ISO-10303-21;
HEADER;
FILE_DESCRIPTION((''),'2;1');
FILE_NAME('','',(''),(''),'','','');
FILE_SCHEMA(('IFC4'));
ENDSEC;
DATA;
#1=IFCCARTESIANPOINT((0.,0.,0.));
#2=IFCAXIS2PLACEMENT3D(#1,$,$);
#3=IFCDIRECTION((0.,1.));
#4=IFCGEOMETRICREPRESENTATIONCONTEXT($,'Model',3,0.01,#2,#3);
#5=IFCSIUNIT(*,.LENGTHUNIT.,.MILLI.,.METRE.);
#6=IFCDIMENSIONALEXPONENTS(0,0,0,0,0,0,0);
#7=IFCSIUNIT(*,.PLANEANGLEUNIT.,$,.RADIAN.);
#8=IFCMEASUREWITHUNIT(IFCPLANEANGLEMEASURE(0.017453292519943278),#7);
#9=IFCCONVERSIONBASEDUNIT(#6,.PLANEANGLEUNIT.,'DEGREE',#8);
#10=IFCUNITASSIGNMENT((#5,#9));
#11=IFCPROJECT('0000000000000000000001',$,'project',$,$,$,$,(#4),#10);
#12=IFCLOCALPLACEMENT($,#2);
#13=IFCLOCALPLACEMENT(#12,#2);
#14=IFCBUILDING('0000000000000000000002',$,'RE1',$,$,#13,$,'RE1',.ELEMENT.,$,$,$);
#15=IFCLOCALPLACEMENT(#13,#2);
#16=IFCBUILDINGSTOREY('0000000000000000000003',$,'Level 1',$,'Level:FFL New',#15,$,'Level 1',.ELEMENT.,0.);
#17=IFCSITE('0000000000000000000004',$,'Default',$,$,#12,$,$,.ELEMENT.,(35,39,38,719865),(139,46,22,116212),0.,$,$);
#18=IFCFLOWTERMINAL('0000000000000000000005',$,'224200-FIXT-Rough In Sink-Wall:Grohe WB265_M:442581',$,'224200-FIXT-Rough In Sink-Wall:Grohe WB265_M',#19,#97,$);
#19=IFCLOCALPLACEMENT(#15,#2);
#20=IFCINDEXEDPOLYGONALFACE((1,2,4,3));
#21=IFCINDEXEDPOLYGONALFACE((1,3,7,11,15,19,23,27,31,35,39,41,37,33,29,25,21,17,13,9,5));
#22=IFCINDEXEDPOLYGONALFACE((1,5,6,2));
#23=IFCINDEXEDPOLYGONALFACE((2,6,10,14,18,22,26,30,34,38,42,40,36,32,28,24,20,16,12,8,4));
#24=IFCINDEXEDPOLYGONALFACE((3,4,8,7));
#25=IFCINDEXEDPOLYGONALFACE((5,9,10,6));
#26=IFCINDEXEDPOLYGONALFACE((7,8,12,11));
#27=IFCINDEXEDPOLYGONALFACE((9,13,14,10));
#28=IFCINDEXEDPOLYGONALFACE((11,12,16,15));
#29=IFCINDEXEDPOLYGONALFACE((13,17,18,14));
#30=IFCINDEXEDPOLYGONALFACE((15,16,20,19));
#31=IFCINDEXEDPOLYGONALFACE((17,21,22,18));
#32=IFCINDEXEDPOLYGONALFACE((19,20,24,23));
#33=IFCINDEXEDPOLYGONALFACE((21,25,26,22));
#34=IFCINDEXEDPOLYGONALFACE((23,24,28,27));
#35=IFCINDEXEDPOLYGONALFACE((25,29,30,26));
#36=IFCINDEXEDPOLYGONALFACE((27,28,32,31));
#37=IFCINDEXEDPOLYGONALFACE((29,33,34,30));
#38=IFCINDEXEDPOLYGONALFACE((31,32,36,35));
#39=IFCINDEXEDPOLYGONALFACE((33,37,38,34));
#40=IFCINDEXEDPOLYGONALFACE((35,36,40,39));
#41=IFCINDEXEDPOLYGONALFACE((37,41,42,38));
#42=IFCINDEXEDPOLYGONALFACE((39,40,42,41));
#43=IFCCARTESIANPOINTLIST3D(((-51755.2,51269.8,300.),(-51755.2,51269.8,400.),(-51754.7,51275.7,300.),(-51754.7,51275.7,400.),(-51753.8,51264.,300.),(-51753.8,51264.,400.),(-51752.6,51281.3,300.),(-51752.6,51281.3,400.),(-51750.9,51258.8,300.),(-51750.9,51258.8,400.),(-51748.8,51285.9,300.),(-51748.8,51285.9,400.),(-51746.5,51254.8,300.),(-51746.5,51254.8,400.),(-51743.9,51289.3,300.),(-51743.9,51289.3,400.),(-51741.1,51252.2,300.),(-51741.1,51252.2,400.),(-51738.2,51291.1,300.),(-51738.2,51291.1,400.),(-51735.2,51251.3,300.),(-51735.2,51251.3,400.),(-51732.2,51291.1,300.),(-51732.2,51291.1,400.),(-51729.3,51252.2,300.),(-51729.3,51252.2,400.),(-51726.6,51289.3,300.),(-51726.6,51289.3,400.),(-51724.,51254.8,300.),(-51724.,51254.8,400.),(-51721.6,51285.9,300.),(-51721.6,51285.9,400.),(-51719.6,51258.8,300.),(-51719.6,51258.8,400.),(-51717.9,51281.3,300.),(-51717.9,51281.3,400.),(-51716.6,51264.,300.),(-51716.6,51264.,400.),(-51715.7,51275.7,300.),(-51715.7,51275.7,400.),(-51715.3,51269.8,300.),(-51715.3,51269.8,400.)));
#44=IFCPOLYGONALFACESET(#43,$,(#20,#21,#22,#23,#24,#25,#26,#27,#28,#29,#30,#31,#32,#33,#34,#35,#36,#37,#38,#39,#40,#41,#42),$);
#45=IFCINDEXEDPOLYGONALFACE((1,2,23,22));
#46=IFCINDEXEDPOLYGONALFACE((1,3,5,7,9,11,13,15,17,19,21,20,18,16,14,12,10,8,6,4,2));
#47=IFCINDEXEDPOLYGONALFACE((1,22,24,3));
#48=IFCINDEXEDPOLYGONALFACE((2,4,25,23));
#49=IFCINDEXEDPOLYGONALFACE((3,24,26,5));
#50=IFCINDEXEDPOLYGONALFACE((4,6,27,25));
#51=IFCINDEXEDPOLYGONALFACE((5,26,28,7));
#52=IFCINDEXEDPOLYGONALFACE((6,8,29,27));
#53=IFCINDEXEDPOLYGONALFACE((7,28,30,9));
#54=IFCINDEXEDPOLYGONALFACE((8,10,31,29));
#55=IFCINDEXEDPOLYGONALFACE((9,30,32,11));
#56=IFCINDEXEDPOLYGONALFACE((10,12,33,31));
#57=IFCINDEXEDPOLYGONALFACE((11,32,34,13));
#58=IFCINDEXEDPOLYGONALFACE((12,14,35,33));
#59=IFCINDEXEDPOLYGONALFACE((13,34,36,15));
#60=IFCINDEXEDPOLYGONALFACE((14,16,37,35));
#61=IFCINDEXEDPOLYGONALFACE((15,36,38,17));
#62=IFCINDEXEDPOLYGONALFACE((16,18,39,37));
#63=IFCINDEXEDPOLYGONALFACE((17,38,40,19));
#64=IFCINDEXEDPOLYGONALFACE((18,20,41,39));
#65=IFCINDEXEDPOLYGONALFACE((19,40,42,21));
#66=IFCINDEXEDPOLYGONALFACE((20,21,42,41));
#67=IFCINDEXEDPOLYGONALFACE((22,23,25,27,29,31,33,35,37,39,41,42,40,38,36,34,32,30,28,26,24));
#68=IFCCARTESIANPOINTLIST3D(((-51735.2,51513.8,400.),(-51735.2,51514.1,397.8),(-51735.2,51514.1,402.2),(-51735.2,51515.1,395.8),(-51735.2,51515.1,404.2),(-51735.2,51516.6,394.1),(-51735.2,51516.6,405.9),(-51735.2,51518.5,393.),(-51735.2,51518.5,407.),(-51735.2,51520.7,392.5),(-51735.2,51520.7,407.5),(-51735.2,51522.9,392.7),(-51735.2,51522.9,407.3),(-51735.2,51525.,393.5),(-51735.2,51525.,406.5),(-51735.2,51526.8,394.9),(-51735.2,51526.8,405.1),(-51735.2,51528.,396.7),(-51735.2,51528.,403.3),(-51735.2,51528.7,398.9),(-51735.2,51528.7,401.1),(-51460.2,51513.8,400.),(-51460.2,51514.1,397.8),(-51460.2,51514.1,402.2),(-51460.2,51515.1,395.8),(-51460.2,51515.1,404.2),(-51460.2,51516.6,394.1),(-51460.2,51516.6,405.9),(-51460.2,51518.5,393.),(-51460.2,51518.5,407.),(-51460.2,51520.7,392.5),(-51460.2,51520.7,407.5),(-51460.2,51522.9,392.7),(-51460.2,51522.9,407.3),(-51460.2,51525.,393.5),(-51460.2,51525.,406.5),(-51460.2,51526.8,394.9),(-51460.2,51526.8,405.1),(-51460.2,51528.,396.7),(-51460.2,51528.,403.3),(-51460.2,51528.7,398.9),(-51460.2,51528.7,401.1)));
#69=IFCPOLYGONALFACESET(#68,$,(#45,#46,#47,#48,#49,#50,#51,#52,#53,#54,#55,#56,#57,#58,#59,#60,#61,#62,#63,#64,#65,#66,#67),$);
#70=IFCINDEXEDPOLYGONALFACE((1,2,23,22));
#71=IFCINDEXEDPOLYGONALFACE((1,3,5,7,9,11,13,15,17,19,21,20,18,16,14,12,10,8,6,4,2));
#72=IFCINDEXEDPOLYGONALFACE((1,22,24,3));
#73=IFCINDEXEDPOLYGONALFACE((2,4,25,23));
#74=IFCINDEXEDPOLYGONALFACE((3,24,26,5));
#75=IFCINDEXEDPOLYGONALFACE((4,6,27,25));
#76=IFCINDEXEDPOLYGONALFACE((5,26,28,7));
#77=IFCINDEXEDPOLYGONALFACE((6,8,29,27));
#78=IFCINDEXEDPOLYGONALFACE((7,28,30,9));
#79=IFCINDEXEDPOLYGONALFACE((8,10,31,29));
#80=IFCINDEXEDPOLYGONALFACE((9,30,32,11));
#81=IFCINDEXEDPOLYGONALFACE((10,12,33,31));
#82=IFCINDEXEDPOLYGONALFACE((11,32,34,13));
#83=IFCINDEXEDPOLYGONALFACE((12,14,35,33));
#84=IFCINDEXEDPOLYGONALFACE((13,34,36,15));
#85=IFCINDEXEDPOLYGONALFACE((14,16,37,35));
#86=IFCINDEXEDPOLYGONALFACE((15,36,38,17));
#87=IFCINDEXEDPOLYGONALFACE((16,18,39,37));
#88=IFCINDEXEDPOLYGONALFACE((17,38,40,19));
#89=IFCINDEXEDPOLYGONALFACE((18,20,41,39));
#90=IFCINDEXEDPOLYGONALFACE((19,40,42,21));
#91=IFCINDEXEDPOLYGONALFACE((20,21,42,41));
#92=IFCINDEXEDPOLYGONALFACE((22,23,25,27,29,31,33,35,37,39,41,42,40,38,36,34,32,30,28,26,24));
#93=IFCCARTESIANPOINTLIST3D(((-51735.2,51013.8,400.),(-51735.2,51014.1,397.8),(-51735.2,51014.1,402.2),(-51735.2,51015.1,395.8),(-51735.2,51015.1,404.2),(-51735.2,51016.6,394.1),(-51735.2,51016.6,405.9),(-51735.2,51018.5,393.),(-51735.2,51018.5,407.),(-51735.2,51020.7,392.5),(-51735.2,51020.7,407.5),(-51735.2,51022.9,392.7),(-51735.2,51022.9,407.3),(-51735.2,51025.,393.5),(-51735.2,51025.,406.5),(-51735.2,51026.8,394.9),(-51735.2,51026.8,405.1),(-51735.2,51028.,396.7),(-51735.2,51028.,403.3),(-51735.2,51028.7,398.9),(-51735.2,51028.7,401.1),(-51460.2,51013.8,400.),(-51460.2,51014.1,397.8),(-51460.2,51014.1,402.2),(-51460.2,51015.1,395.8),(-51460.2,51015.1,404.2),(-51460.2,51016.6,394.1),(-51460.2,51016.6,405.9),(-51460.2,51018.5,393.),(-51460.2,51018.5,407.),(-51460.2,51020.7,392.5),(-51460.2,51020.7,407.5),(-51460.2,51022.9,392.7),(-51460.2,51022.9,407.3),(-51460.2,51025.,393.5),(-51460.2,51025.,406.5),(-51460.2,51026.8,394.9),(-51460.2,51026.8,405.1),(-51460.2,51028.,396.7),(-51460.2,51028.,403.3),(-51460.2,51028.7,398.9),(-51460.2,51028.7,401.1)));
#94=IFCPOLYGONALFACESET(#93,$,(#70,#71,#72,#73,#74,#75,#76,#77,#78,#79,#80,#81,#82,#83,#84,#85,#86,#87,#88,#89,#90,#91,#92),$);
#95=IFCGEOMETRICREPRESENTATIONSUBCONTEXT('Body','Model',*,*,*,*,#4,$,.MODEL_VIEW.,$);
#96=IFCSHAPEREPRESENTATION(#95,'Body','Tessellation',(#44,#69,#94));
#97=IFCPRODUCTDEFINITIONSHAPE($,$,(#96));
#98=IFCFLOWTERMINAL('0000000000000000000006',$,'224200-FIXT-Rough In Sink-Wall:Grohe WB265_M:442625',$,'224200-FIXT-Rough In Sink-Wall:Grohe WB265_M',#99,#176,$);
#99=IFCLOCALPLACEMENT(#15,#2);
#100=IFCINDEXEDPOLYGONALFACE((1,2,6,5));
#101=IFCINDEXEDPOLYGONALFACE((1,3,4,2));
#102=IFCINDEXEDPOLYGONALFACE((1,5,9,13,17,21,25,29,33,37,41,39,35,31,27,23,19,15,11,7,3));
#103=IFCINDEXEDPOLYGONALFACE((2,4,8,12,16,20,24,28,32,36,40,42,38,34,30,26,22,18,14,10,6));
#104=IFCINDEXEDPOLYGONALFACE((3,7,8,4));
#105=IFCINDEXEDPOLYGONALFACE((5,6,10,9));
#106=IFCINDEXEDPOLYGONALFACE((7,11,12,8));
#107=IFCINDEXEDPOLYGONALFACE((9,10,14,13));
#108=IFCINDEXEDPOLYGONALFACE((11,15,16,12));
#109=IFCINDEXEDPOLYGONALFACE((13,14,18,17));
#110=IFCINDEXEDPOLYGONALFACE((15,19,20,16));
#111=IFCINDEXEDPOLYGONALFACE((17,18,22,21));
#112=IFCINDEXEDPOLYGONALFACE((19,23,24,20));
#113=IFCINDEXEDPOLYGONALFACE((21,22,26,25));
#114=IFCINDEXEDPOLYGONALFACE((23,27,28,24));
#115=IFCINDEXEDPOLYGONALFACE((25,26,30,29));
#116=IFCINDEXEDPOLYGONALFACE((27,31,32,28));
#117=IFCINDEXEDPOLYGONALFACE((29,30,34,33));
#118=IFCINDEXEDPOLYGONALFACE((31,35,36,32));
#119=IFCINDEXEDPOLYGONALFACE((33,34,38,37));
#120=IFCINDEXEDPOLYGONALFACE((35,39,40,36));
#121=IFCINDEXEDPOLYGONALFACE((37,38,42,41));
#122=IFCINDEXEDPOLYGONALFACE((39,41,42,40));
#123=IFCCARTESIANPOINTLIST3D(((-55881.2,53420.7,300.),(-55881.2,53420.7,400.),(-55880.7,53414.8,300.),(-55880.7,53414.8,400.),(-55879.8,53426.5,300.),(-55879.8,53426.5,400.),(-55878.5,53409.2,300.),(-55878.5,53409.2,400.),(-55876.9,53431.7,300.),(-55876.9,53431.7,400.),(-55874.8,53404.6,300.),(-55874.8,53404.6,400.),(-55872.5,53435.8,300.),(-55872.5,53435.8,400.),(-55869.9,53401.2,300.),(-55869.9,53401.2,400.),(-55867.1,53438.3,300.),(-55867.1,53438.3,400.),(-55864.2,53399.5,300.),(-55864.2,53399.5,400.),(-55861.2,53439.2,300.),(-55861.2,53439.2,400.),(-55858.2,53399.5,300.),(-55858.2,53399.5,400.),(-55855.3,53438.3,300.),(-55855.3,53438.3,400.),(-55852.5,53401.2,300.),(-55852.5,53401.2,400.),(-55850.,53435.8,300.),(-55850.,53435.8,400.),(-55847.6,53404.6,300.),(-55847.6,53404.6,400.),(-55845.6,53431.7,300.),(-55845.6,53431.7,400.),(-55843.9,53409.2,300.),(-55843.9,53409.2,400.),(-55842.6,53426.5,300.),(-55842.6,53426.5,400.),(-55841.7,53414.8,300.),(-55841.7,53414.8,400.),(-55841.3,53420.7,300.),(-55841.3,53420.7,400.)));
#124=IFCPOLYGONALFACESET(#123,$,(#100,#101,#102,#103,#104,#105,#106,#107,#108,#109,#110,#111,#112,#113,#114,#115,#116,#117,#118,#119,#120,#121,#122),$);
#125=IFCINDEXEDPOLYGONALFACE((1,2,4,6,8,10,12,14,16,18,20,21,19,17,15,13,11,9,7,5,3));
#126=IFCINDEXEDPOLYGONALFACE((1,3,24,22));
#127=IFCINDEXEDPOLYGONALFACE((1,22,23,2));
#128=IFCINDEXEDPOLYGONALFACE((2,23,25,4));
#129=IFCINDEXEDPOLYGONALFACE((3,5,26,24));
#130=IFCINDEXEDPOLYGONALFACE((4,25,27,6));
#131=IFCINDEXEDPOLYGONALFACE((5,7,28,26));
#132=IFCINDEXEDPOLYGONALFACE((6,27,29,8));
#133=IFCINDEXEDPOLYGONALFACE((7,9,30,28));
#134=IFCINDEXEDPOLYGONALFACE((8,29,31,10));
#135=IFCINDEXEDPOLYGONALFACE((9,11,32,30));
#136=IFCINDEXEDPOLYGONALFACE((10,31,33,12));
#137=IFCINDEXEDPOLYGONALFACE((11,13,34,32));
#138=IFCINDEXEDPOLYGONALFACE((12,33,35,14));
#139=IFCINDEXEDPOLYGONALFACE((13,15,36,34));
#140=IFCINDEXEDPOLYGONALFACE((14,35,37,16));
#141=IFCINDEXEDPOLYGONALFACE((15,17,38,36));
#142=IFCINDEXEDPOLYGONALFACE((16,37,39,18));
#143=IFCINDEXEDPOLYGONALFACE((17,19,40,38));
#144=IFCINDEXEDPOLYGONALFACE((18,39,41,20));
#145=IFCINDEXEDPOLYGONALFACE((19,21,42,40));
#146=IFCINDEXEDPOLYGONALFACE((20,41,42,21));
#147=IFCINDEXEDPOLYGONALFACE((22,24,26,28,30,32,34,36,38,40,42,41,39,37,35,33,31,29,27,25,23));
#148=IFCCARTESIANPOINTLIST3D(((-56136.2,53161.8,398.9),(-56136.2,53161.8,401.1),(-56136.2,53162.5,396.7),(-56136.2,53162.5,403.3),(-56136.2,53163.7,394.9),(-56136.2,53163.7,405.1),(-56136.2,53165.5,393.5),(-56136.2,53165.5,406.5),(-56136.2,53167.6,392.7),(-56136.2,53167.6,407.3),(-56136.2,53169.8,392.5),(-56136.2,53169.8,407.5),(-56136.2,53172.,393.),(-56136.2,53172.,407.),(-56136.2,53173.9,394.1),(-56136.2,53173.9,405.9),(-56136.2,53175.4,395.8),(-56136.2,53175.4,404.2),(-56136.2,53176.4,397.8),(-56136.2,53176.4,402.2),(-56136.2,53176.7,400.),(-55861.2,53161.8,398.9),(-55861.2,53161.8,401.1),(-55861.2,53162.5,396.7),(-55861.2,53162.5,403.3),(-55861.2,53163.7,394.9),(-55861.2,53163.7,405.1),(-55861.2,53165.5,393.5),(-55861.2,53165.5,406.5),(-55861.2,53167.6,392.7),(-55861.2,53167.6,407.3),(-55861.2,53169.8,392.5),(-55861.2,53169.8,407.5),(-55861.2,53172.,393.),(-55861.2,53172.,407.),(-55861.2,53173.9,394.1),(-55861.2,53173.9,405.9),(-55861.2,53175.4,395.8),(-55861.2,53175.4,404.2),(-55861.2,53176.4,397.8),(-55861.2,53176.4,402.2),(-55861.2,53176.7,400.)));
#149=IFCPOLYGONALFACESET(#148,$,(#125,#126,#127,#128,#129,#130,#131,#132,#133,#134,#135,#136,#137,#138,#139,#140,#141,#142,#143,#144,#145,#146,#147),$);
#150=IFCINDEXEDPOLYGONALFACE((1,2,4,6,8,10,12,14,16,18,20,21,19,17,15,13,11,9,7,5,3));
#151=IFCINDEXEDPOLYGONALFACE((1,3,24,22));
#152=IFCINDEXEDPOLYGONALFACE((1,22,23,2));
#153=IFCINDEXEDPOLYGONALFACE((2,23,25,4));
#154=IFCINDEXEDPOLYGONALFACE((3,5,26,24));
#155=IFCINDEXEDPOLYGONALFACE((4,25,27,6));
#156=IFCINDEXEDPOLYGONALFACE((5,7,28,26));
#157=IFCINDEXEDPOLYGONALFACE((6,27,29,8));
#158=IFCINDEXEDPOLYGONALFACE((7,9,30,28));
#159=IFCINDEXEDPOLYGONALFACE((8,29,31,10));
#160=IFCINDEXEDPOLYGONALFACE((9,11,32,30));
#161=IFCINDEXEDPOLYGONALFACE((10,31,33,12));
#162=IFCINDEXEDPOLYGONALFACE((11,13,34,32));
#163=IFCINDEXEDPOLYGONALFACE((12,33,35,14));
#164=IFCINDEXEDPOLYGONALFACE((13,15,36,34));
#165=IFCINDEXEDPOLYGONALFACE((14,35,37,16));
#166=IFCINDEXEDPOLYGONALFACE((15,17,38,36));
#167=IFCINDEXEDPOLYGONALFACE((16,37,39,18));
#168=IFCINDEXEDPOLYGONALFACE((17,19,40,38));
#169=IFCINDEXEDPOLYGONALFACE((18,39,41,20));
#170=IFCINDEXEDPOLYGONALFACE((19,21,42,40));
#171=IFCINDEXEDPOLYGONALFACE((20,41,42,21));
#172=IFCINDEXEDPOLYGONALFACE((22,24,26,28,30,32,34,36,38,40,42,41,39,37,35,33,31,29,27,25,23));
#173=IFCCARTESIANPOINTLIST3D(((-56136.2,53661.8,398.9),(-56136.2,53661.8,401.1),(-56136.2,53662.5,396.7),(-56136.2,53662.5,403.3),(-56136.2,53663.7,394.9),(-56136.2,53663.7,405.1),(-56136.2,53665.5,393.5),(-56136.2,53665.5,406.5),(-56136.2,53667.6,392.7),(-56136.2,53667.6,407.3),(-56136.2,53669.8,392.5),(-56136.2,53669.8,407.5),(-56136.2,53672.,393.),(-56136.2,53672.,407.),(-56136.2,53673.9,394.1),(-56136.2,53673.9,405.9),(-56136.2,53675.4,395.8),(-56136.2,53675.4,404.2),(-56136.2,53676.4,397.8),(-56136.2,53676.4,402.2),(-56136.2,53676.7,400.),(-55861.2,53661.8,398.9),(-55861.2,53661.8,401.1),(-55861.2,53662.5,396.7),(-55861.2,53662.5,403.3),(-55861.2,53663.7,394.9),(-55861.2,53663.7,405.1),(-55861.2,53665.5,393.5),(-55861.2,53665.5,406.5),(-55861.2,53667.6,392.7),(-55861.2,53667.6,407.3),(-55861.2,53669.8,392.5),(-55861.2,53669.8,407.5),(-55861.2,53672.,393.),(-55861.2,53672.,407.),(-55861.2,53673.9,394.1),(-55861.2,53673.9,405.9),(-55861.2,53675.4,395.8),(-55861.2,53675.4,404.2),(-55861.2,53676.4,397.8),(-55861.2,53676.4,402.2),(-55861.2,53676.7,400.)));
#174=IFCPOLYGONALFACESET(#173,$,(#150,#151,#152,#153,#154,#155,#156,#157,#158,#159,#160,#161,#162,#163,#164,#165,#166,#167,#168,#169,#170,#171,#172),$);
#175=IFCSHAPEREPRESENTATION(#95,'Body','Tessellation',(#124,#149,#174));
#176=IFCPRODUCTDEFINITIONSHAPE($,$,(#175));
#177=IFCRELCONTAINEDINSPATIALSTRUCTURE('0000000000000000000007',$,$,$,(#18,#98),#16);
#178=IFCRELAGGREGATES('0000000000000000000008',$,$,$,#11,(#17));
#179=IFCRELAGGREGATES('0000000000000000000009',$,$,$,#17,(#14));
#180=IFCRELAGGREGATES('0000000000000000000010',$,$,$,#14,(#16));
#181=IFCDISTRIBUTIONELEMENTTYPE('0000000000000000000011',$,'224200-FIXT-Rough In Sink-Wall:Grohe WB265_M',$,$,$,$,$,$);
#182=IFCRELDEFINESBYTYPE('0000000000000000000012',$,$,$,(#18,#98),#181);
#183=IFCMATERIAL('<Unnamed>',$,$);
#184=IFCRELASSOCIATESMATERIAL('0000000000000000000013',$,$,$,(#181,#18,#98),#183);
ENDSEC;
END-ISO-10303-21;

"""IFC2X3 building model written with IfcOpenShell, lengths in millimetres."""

from ifc_helpers import new_model, entity, si_unit, converted_unit, direction, frame, frame_2d, origin, place, context, subcontext, project, spatial, circle, extrude, source, transform, mapped, material, type_object, type_shapes, element, save


model = new_model("IFC2X3")

# Units and contexts
model_context = context("Model", 3, precision=0.01, world=origin(), true_north=direction((0.0, 1.0)))
body_context = subcontext(model_context, "Body", "Model", "MODEL_VIEW")
ifc_project = project(units=[si_unit("LENGTHUNIT", "METRE", prefix="MILLI"), converted_unit("PLANEANGLEUNIT", "DEGREE", entity("IfcPlaneAngleMeasure", 0.017453292519943278), si_unit("PLANEANGLEUNIT", "RADIAN"), dimensions=[0, 0, 0, 0, 0, 0, 0])], contexts=[model_context])

# Site, building, storey
site_placement = place(None, origin())
site = spatial("IfcSite", under=ifc_project, at=site_placement, Name="Default", CompositionType="ELEMENT", RefLatitude=(35, 39, 38, 719865), RefLongitude=(139, 46, 22, 116212), RefElevation=0.0)
building_placement = place(site_placement, origin())
building = spatial("IfcBuilding", under=site, at=building_placement, Name="RE1", LongName="RE1", CompositionType="ELEMENT")
storey_placement = place(building_placement, origin())
storey = spatial("IfcBuildingStorey", under=building, at=storey_placement, Name="Level 1", ObjectType="Level:FFL New", LongName="Level 1", CompositionType="ELEMENT", Elevation=0.0)

# Flow terminals
ifc_material = material(Name="<Unnamed>")
distribution_element_type_1 = type_object("IfcDistributionElementType", Name="224200-FIXT-Rough In Sink-Wall:Grohe WB265_M", material=ifc_material)
shared_shape_1 = source(origin(), body_context, "Body", "SweptSolid", [
    extrude(circle(Radius=20.0, at=frame_2d((0.0, 0.0), x_axis=(1.0, 0.0))), frame((0.0, -100.0, 275.0), z_axis=(0.0, 1.0, 0.0), x_axis=(1.0, 0.0, 0.0)), (0.0, 0.0, 1.0), 100.0),
    extrude(circle(Radius=7.5, at=frame_2d((0.0, 0.0), x_axis=(1.0, 0.0))), frame((-250.0, 0.0, 0.0)), (0.0, 0.0, 1.0), 275.0),
    extrude(circle(Radius=7.5, at=frame_2d((0.0, 0.0), x_axis=(1.0, 0.0))), frame((250.0, 0.0, 0.0)), (0.0, 0.0, 1.0), 275.0),
])
type_shapes(distribution_element_type_1, [shared_shape_1])
for number, where, z_axis, x_axis, name in (
    (1, (-51460.2, 51271.3, 400.0), (-1.0, -0.000011, 0.0), (0.000011, -1.0, 0.0), "224200-FIXT-Rough In Sink-Wall:Grohe WB265_M:442581"),
    (2, (-56136.2, 53419.2, 400.0), (1.0, 0.000004, 0.0), (-0.000004, 1.0, 0.0), "224200-FIXT-Rough In Sink-Wall:Grohe WB265_M:442625"),
):
    element("IfcFlowTerminal", number, at=place(storey_placement, frame(where, z_axis=z_axis, x_axis=x_axis)), inside=storey, type_object=distribution_element_type_1, material=ifc_material, Name=name, ObjectType="224200-FIXT-Rough In Sink-Wall:Grohe WB265_M", context=body_context, shape_type="MappedRepresentation", body=[
        mapped(shared_shape_1, transform((0.0, 0.0, 0.0), scale=1.0)),
    ])

save(model, "model.ifc")
